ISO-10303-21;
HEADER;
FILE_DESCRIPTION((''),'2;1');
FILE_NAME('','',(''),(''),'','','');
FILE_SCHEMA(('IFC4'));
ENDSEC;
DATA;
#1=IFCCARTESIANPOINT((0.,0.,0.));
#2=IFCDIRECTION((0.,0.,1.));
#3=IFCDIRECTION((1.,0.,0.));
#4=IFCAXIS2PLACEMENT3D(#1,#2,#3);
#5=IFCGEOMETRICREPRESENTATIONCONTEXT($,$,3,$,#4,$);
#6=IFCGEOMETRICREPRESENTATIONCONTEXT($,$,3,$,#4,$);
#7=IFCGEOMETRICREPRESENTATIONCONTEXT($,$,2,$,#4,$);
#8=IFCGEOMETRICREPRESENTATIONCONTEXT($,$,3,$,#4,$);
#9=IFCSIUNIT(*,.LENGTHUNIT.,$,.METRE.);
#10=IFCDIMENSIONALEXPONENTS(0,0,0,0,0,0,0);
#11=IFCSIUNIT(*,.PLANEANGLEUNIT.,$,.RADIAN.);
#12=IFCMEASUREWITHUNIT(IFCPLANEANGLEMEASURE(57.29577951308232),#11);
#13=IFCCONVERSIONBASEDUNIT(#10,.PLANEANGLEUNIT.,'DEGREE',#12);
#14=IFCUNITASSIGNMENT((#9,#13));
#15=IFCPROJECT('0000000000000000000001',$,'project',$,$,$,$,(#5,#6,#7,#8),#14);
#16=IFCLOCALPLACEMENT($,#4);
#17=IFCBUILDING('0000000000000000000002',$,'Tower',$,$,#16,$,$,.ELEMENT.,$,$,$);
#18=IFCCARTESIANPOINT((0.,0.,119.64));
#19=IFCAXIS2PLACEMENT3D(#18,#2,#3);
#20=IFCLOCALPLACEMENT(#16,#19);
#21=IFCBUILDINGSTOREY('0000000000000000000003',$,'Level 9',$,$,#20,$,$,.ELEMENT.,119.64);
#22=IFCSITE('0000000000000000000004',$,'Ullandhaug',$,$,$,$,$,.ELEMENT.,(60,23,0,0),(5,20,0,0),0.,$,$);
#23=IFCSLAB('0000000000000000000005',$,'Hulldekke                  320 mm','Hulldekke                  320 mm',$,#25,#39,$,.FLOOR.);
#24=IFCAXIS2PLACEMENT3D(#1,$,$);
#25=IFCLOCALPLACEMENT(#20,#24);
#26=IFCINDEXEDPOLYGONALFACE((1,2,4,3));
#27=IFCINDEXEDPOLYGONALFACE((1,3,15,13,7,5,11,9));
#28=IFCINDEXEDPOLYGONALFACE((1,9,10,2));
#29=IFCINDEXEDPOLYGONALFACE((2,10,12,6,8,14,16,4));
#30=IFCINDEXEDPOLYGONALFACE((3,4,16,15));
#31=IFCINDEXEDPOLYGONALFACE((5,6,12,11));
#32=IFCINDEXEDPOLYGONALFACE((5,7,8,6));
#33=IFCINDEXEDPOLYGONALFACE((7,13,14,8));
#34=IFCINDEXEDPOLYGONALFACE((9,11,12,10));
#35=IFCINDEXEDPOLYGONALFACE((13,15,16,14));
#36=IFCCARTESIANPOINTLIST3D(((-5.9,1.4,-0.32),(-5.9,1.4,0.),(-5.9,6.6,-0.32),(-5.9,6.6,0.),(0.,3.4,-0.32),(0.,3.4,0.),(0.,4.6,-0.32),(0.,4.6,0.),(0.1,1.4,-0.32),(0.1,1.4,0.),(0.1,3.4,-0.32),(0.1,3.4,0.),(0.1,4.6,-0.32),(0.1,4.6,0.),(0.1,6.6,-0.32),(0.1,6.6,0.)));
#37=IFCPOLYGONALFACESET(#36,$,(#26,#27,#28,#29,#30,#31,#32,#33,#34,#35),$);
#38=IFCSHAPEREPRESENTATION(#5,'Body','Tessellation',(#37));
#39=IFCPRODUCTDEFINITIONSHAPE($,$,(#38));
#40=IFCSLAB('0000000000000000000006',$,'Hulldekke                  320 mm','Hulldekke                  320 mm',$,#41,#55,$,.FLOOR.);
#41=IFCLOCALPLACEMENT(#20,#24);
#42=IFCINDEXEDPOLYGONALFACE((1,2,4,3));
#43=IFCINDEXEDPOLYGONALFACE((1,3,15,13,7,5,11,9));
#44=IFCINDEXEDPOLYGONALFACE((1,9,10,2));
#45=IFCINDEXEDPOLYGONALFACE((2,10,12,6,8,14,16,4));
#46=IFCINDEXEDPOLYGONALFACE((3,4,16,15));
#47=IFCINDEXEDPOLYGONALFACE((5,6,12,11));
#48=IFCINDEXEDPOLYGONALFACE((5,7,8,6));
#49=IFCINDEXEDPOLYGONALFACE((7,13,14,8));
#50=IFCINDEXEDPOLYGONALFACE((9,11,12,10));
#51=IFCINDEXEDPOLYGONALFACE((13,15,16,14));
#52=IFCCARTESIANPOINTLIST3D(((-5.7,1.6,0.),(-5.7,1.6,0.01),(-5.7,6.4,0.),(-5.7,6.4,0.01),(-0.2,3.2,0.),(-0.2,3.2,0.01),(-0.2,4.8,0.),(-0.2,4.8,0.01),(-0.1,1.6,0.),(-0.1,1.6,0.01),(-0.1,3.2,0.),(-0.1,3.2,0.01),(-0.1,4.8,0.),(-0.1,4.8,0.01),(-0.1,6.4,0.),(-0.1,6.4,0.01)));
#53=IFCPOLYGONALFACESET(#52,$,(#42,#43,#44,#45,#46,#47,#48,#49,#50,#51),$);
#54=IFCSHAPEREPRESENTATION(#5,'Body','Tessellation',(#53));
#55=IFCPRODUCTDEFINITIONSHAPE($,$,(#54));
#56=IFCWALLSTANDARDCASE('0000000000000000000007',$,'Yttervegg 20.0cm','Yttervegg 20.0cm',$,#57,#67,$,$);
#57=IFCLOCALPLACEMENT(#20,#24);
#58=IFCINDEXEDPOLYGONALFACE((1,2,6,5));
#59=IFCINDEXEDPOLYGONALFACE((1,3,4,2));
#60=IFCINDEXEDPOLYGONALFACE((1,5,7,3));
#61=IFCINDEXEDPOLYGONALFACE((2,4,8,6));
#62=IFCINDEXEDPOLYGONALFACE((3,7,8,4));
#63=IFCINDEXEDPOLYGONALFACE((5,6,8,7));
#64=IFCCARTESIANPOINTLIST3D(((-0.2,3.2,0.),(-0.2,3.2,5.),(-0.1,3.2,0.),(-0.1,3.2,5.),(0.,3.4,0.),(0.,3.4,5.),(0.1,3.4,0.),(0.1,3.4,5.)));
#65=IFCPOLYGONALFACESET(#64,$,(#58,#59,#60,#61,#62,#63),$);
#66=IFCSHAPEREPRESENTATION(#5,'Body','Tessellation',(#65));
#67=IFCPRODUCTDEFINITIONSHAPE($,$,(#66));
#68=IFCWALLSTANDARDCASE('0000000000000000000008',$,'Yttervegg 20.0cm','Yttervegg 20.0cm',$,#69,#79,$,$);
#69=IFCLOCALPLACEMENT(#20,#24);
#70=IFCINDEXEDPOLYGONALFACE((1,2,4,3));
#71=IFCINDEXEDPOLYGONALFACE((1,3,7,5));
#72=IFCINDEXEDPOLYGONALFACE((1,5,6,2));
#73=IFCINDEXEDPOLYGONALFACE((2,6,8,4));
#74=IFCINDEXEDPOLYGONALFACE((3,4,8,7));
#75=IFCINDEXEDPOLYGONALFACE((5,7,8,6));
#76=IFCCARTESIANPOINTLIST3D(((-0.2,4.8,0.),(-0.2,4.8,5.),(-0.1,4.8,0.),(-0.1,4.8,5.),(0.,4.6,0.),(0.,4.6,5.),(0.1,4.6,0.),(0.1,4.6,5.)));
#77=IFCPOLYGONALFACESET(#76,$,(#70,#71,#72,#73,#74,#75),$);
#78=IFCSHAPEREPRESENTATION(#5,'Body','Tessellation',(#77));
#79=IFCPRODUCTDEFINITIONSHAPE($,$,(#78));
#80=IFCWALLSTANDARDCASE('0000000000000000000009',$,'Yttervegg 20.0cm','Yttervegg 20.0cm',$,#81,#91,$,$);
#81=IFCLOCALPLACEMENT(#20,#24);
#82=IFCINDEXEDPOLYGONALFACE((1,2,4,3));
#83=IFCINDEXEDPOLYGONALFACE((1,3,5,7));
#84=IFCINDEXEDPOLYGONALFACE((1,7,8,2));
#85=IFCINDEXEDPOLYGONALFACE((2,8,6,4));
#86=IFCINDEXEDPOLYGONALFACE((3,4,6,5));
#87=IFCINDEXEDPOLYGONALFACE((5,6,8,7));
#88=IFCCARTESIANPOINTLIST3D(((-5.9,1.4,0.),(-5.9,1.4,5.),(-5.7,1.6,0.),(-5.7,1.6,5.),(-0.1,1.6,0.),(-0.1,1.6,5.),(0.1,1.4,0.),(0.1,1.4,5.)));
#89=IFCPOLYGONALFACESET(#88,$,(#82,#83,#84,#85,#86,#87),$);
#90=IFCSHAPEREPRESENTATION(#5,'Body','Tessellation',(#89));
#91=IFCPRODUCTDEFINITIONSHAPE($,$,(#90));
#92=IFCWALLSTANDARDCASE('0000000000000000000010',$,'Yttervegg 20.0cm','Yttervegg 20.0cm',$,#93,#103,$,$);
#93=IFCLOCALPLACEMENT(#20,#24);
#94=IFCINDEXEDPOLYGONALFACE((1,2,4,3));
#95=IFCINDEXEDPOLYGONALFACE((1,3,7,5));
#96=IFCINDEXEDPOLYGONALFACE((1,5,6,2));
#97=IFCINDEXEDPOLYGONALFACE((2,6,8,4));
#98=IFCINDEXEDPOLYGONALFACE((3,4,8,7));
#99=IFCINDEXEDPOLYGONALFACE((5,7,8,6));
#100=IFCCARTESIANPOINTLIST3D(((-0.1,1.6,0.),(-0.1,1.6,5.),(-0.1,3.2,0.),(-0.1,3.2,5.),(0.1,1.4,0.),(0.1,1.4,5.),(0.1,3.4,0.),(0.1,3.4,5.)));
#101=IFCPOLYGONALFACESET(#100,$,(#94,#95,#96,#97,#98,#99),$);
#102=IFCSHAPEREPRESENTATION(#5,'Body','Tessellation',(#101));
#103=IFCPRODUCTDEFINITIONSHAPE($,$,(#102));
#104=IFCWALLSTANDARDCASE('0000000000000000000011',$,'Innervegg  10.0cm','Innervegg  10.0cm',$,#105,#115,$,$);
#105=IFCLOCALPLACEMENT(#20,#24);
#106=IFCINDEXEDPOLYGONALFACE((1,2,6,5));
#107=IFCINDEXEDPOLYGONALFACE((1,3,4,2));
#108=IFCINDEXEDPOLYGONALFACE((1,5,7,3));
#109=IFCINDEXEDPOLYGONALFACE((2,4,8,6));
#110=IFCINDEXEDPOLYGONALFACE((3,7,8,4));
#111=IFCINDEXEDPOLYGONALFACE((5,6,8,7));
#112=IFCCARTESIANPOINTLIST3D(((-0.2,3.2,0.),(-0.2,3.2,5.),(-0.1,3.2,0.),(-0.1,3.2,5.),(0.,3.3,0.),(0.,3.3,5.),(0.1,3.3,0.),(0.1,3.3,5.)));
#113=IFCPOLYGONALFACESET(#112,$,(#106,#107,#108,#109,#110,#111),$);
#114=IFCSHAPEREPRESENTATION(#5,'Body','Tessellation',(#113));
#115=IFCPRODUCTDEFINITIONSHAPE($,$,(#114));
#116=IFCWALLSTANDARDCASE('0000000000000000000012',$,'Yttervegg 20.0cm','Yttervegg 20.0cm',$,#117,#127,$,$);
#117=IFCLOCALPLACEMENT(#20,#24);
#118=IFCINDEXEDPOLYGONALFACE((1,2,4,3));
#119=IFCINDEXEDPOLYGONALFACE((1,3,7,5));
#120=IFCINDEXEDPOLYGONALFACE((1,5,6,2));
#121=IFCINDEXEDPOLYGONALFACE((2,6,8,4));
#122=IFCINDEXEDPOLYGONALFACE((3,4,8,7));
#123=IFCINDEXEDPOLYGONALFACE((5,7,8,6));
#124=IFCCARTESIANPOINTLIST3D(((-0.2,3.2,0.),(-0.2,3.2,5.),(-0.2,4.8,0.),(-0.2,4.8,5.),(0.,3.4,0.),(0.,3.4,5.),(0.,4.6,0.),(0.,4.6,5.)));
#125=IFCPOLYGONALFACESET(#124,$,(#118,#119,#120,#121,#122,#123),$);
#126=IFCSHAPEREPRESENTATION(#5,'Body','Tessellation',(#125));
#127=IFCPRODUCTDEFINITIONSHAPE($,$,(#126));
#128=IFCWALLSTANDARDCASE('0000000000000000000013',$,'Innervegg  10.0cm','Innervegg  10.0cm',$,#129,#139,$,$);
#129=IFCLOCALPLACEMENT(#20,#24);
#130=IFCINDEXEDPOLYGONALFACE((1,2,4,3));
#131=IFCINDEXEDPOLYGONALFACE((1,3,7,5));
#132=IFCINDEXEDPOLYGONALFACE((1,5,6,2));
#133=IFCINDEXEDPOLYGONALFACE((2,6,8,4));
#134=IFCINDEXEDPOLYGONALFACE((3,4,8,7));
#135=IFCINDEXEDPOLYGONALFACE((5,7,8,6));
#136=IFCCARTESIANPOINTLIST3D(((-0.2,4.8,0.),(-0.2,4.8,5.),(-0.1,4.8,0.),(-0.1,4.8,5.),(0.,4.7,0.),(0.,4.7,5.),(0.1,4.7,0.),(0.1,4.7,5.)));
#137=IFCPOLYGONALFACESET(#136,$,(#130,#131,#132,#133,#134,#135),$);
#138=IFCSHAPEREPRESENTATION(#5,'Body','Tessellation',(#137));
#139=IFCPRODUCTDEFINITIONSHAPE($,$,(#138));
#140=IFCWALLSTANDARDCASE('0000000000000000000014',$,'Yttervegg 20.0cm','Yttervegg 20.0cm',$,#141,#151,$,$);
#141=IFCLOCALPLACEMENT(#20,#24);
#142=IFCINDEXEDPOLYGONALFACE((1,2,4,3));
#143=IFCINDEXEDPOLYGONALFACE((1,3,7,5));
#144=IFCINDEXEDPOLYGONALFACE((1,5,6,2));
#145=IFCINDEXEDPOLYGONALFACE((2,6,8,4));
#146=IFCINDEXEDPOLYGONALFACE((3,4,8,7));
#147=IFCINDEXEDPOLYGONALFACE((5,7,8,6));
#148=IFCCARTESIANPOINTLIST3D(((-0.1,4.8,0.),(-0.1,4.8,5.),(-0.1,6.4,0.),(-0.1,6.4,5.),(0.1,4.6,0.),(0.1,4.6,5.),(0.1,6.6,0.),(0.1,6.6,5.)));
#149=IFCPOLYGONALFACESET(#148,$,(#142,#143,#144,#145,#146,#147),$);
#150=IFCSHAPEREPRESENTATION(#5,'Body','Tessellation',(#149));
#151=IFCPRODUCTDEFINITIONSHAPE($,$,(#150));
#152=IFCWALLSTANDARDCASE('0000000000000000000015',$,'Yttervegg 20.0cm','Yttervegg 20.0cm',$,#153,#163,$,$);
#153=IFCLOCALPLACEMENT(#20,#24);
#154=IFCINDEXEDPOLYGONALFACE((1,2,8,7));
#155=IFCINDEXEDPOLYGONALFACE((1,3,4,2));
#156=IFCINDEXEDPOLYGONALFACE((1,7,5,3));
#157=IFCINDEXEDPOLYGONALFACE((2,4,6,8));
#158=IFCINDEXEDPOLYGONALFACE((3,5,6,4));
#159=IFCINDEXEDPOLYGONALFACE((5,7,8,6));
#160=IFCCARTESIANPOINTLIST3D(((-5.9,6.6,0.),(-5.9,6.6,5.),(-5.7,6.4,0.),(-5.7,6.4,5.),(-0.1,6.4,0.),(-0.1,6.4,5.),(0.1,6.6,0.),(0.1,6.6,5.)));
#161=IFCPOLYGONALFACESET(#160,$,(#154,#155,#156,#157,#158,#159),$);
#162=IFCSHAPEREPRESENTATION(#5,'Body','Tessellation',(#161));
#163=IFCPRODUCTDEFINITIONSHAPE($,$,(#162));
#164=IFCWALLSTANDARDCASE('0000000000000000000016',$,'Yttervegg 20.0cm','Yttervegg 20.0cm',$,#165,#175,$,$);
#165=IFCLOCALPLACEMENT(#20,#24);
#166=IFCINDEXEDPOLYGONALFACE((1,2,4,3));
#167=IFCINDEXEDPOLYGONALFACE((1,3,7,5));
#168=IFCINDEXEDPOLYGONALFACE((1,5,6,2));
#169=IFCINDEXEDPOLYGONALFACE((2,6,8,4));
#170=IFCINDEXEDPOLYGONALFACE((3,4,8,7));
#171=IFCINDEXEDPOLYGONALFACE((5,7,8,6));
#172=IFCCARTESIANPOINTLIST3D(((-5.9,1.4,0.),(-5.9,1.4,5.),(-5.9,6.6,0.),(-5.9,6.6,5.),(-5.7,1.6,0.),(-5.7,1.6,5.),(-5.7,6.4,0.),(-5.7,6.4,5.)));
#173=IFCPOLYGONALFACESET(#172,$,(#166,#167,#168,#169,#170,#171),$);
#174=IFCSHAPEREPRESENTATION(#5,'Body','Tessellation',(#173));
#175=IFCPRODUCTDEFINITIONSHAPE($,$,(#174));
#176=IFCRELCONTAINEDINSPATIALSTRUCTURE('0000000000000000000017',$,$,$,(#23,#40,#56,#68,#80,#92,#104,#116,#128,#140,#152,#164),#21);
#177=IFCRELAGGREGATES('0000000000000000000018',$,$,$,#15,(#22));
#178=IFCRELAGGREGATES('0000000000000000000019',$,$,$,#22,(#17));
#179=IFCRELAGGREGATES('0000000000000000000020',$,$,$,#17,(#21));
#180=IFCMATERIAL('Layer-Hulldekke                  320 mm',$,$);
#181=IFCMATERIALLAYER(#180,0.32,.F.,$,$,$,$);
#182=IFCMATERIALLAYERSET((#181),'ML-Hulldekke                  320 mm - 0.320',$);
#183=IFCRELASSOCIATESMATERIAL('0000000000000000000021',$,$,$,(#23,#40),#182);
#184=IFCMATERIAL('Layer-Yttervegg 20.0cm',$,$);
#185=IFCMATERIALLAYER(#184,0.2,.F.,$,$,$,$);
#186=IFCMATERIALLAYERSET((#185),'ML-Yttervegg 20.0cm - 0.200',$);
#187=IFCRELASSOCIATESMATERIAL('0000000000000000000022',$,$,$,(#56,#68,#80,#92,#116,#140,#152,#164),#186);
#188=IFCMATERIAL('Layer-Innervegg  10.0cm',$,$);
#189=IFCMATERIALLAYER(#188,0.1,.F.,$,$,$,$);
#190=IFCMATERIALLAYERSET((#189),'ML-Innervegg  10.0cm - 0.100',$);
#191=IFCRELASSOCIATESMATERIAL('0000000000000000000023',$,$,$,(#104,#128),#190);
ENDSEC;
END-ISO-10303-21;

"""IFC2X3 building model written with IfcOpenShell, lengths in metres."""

from ifc_helpers import new_model, entity, si_unit, converted_unit, frame, origin_with_axes, place, context, project, spatial, polyline, outline, extrude, material, layer, layer_set, layer_usage, element, save


model = new_model("IFC2X3")

# Units and contexts
context_of_model_1 = context(None, 3, world=origin_with_axes())
context_of_model_2 = context(None, 3, world=origin_with_axes())
context_of_model_3 = context(None, 2, world=origin_with_axes())
context_of_model_4 = context(None, 3, world=origin_with_axes())
ifc_project = project(units=[si_unit("LENGTHUNIT", "METRE"), converted_unit("PLANEANGLEUNIT", "DEGREE", entity("IfcPlaneAngleMeasure", 57.29577951308232), si_unit("PLANEANGLEUNIT", "RADIAN"), dimensions=[0, 0, 0, 0, 0, 0, 0])], contexts=[context_of_model_1, context_of_model_2, context_of_model_3, context_of_model_4])

# Site, building, storey
site = spatial("IfcSite", under=ifc_project, Name="Ullandhaug", CompositionType="ELEMENT", RefLatitude=(60, 23, 0, 0), RefLongitude=(5, 20, 0, 0), RefElevation=0.0)
building_placement = place(None, origin_with_axes())
building = spatial("IfcBuilding", under=site, at=building_placement, Name="Tower", CompositionType="ELEMENT")
storey_placement = place(building_placement, frame((0.0, 0.0, 119.64), z_axis=(0.0, 0.0, 1.0), x_axis=(1.0, 0.0, 0.0)))
storey = spatial("IfcBuildingStorey", under=building, at=storey_placement, Name="Level 9", CompositionType="ELEMENT", Elevation=119.64)

# Slabs
ifc_material_1 = material(Name="Layer-Hulldekke                  320 mm")
ifc_layer_1 = layer(ifc_material_1, 0.32, ventilated=False)
ifc_layer_set_1 = layer_set([ifc_layer_1], Name="ML-Hulldekke                  320 mm - 0.320")
ifc_layer_usage_1 = layer_usage(ifc_layer_set_1, "AXIS2", "POSITIVE", 0.0)
slab_1_placement = place(storey_placement, frame((-5.9, 1.4, 0.0), z_axis=(0.0, 0.0, 1.0), x_axis=(1.0, 0.0, 0.0)))
element("IfcSlab", 1, at=slab_1_placement, inside=storey, material=ifc_layer_usage_1, Name="Hulldekke                  320 mm", Description="Hulldekke                  320 mm", PredefinedType="FLOOR", context=context_of_model_1, shape_type="SweptSolid", body=[
    extrude(outline(polyline([(0.0, 0.0), (6.0, 0.0), (6.0, 2.0), (5.9, 2.0), (5.9, 3.2), (6.0, 3.2), (6.0, 5.2), (0.0, 5.2), (0.0, 0.0)])), origin_with_axes(), (0.0, 0.0, -1.0), 0.32),
])
slab_2_placement = place(storey_placement, frame((-5.7, 1.6, 0.0), z_axis=(0.0, 0.0, 1.0), x_axis=(1.0, 0.0, 0.0)))
element("IfcSlab", 2, at=slab_2_placement, inside=storey, material=ifc_layer_usage_1, Name="Hulldekke                  320 mm", Description="Hulldekke                  320 mm", PredefinedType="FLOOR", context=context_of_model_1, shape_type="SweptSolid", body=[
    extrude(outline(polyline([(0.0, 0.0), (5.6, 0.0), (5.6, 1.6), (5.5, 1.6), (5.5, 3.2), (5.6, 3.2), (5.6, 4.8), (0.0, 4.8), (0.0, 0.0)])), origin_with_axes(), (0.0, 0.0, 1.0), 0.01),
])

# Walls
ifc_material_2 = material(Name="Layer-Yttervegg 20.0cm")
ifc_layer_2 = layer(ifc_material_2, 0.2, ventilated=False)
ifc_layer_set_2 = layer_set([ifc_layer_2], Name="ML-Yttervegg 20.0cm - 0.200")
ifc_layer_usage_2 = layer_usage(ifc_layer_set_2, "AXIS2", "POSITIVE", 0.0)
wall_1_placement = place(storey_placement, frame((0.1, 3.4, 0.0), z_axis=(0.0, 0.0, 1.0), x_axis=(-1.0, 0.0, 0.0)))
element("IfcWallStandardCase", 3, at=wall_1_placement, inside=storey, material=ifc_layer_usage_2, Name="Yttervegg 20.0cm", Description="Yttervegg 20.0cm", context=context_of_model_1, shape_type="SweptSolid", body=[
    extrude(outline(polyline([(0.0, 0.0), (0.1, 0.0), (0.3, 0.2), (0.2, 0.2), (0.0, 0.0)])), frame((0.0, 0.0, 0.0), z_axis=(0.0, 0.0, 1.0), x_axis=(1.0, 0.0, 0.0)), (0.0, 0.0, 1.0), 5.0),
])
wall_2_placement = place(storey_placement, frame((0.0, 4.6, 0.0), z_axis=(0.0, 0.0, 1.0), x_axis=(1.0, 0.0, 0.0)))
element("IfcWallStandardCase", 4, at=wall_2_placement, inside=storey, material=ifc_layer_usage_2, Name="Yttervegg 20.0cm", Description="Yttervegg 20.0cm", context=context_of_model_1, shape_type="SweptSolid", body=[
    extrude(outline(polyline([(0.0, 0.0), (0.1, 0.0), (-0.1, 0.2), (-0.2, 0.2), (0.0, 0.0)])), origin_with_axes(), (0.0, 0.0, 1.0), 5.0),
])
wall_3_placement = place(storey_placement, frame((-5.9, 1.4, 0.0), z_axis=(0.0, 0.0, 1.0), x_axis=(1.0, 0.0, 0.0)))
element("IfcWallStandardCase", 5, at=wall_3_placement, inside=storey, material=ifc_layer_usage_2, Name="Yttervegg 20.0cm", Description="Yttervegg 20.0cm", context=context_of_model_1, shape_type="SweptSolid", body=[
    extrude(outline(polyline([(0.0, 0.0), (6.0, 0.0), (5.8, 0.2), (0.2, 0.2), (0.0, 0.0)])), origin_with_axes(), (0.0, 0.0, 1.0), 5.0),
])
wall_4_placement = place(storey_placement, frame((0.1, 1.4, 0.0), z_axis=(0.0, 0.0, 1.0), x_axis=(0.0, 1.0, 0.0)))
element("IfcWallStandardCase", 6, at=wall_4_placement, inside=storey, material=ifc_layer_usage_2, Name="Yttervegg 20.0cm", Description="Yttervegg 20.0cm", context=context_of_model_1, shape_type="SweptSolid", body=[
    extrude(outline(polyline([(0.0, 0.0), (2.0, 0.0), (1.8, 0.2), (0.2, 0.2), (0.0, 0.0)])), frame((0.0, 0.0, 0.0), z_axis=(0.0, 0.0, 1.0), x_axis=(1.0, 0.0, 0.0)), (0.0, 0.0, 1.0), 5.0),
])
ifc_material_3 = material(Name="Layer-Innervegg  10.0cm")
ifc_layer_3 = layer(ifc_material_3, 0.1, ventilated=False)
ifc_layer_set_3 = layer_set([ifc_layer_3], Name="ML-Innervegg  10.0cm - 0.100")
ifc_layer_usage_3 = layer_usage(ifc_layer_set_3, "AXIS2", "POSITIVE", 0.0)
wall_5_placement = place(storey_placement, frame((0.1, 3.3, 0.0), z_axis=(0.0, 0.0, 1.0), x_axis=(-1.0, 0.0, 0.0)))
element("IfcWallStandardCase", 7, at=wall_5_placement, inside=storey, material=ifc_layer_usage_3, Name="Innervegg  10.0cm", Description="Innervegg  10.0cm", context=context_of_model_1, shape_type="SweptSolid", body=[
    extrude(outline(polyline([(0.0, 0.0), (0.1, 0.0), (0.3, 0.1), (0.2, 0.1), (0.0, 0.0)])), frame((0.0, 0.0, 0.0), z_axis=(0.0, 0.0, 1.0), x_axis=(1.0, 0.0, 0.0)), (0.0, 0.0, 1.0), 5.0),
])
wall_6_placement = place(storey_placement, frame((0.0, 3.4, 0.0), z_axis=(0.0, 0.0, 1.0), x_axis=(0.0, 1.0, 0.0)))
element("IfcWallStandardCase", 8, at=wall_6_placement, inside=storey, material=ifc_layer_usage_2, Name="Yttervegg 20.0cm", Description="Yttervegg 20.0cm", context=context_of_model_1, shape_type="SweptSolid", body=[
    extrude(outline(polyline([(0.0, 0.0), (1.2, 0.0), (1.4, 0.2), (-0.2, 0.2), (0.0, 0.0)])), frame((0.0, 0.0, 0.0), z_axis=(0.0, 0.0, 1.0), x_axis=(1.0, 0.0, 0.0)), (0.0, 0.0, 1.0), 5.0),
])
wall_7_placement = place(storey_placement, frame((0.0, 4.7, 0.0), z_axis=(0.0, 0.0, 1.0), x_axis=(1.0, 0.0, 0.0)))
element("IfcWallStandardCase", 9, at=wall_7_placement, inside=storey, material=ifc_layer_usage_3, Name="Innervegg  10.0cm", Description="Innervegg  10.0cm", context=context_of_model_1, shape_type="SweptSolid", body=[
    extrude(outline(polyline([(0.0, 0.0), (0.1, 0.0), (-0.1, 0.1), (-0.2, 0.1), (0.0, 0.0)])), origin_with_axes(), (0.0, 0.0, 1.0), 5.0),
])
wall_8_placement = place(storey_placement, frame((0.1, 4.6, 0.0), z_axis=(0.0, 0.0, 1.0), x_axis=(0.0, 1.0, 0.0)))
element("IfcWallStandardCase", 10, at=wall_8_placement, inside=storey, material=ifc_layer_usage_2, Name="Yttervegg 20.0cm", Description="Yttervegg 20.0cm", context=context_of_model_1, shape_type="SweptSolid", body=[
    extrude(outline(polyline([(0.0, 0.0), (2.0, 0.0), (1.8, 0.2), (0.2, 0.2), (0.0, 0.0)])), frame((0.0, 0.0, 0.0), z_axis=(0.0, 0.0, 1.0), x_axis=(1.0, 0.0, 0.0)), (0.0, 0.0, 1.0), 5.0),
])
wall_9_placement = place(storey_placement, frame((0.1, 6.6, 0.0), z_axis=(0.0, 0.0, 1.0), x_axis=(-1.0, 0.0, 0.0)))
element("IfcWallStandardCase", 11, at=wall_9_placement, inside=storey, material=ifc_layer_usage_2, Name="Yttervegg 20.0cm", Description="Yttervegg 20.0cm", context=context_of_model_1, shape_type="SweptSolid", body=[
    extrude(outline(polyline([(0.0, 0.0), (6.0, 0.0), (5.8, 0.2), (0.2, 0.2), (0.0, 0.0)])), frame((0.0, 0.0, 0.0), z_axis=(0.0, 0.0, 1.0), x_axis=(1.0, 0.0, 0.0)), (0.0, 0.0, 1.0), 5.0),
])
wall_10_placement = place(storey_placement, frame((-5.9, 6.6, 0.0), z_axis=(0.0, 0.0, 1.0), x_axis=(0.0, -1.0, 0.0)))
element("IfcWallStandardCase", 12, at=wall_10_placement, inside=storey, material=ifc_layer_usage_2, Name="Yttervegg 20.0cm", Description="Yttervegg 20.0cm", context=context_of_model_1, shape_type="SweptSolid", body=[
    extrude(outline(polyline([(0.0, 0.0), (5.2, 0.0), (5.0, 0.2), (0.2, 0.2), (0.0, 0.0)])), frame((0.0, 0.0, 0.0), z_axis=(0.0, 0.0, 1.0), x_axis=(1.0, 0.0, 0.0)), (0.0, 0.0, 1.0), 5.0),
])

save(model, "model.ifc")
